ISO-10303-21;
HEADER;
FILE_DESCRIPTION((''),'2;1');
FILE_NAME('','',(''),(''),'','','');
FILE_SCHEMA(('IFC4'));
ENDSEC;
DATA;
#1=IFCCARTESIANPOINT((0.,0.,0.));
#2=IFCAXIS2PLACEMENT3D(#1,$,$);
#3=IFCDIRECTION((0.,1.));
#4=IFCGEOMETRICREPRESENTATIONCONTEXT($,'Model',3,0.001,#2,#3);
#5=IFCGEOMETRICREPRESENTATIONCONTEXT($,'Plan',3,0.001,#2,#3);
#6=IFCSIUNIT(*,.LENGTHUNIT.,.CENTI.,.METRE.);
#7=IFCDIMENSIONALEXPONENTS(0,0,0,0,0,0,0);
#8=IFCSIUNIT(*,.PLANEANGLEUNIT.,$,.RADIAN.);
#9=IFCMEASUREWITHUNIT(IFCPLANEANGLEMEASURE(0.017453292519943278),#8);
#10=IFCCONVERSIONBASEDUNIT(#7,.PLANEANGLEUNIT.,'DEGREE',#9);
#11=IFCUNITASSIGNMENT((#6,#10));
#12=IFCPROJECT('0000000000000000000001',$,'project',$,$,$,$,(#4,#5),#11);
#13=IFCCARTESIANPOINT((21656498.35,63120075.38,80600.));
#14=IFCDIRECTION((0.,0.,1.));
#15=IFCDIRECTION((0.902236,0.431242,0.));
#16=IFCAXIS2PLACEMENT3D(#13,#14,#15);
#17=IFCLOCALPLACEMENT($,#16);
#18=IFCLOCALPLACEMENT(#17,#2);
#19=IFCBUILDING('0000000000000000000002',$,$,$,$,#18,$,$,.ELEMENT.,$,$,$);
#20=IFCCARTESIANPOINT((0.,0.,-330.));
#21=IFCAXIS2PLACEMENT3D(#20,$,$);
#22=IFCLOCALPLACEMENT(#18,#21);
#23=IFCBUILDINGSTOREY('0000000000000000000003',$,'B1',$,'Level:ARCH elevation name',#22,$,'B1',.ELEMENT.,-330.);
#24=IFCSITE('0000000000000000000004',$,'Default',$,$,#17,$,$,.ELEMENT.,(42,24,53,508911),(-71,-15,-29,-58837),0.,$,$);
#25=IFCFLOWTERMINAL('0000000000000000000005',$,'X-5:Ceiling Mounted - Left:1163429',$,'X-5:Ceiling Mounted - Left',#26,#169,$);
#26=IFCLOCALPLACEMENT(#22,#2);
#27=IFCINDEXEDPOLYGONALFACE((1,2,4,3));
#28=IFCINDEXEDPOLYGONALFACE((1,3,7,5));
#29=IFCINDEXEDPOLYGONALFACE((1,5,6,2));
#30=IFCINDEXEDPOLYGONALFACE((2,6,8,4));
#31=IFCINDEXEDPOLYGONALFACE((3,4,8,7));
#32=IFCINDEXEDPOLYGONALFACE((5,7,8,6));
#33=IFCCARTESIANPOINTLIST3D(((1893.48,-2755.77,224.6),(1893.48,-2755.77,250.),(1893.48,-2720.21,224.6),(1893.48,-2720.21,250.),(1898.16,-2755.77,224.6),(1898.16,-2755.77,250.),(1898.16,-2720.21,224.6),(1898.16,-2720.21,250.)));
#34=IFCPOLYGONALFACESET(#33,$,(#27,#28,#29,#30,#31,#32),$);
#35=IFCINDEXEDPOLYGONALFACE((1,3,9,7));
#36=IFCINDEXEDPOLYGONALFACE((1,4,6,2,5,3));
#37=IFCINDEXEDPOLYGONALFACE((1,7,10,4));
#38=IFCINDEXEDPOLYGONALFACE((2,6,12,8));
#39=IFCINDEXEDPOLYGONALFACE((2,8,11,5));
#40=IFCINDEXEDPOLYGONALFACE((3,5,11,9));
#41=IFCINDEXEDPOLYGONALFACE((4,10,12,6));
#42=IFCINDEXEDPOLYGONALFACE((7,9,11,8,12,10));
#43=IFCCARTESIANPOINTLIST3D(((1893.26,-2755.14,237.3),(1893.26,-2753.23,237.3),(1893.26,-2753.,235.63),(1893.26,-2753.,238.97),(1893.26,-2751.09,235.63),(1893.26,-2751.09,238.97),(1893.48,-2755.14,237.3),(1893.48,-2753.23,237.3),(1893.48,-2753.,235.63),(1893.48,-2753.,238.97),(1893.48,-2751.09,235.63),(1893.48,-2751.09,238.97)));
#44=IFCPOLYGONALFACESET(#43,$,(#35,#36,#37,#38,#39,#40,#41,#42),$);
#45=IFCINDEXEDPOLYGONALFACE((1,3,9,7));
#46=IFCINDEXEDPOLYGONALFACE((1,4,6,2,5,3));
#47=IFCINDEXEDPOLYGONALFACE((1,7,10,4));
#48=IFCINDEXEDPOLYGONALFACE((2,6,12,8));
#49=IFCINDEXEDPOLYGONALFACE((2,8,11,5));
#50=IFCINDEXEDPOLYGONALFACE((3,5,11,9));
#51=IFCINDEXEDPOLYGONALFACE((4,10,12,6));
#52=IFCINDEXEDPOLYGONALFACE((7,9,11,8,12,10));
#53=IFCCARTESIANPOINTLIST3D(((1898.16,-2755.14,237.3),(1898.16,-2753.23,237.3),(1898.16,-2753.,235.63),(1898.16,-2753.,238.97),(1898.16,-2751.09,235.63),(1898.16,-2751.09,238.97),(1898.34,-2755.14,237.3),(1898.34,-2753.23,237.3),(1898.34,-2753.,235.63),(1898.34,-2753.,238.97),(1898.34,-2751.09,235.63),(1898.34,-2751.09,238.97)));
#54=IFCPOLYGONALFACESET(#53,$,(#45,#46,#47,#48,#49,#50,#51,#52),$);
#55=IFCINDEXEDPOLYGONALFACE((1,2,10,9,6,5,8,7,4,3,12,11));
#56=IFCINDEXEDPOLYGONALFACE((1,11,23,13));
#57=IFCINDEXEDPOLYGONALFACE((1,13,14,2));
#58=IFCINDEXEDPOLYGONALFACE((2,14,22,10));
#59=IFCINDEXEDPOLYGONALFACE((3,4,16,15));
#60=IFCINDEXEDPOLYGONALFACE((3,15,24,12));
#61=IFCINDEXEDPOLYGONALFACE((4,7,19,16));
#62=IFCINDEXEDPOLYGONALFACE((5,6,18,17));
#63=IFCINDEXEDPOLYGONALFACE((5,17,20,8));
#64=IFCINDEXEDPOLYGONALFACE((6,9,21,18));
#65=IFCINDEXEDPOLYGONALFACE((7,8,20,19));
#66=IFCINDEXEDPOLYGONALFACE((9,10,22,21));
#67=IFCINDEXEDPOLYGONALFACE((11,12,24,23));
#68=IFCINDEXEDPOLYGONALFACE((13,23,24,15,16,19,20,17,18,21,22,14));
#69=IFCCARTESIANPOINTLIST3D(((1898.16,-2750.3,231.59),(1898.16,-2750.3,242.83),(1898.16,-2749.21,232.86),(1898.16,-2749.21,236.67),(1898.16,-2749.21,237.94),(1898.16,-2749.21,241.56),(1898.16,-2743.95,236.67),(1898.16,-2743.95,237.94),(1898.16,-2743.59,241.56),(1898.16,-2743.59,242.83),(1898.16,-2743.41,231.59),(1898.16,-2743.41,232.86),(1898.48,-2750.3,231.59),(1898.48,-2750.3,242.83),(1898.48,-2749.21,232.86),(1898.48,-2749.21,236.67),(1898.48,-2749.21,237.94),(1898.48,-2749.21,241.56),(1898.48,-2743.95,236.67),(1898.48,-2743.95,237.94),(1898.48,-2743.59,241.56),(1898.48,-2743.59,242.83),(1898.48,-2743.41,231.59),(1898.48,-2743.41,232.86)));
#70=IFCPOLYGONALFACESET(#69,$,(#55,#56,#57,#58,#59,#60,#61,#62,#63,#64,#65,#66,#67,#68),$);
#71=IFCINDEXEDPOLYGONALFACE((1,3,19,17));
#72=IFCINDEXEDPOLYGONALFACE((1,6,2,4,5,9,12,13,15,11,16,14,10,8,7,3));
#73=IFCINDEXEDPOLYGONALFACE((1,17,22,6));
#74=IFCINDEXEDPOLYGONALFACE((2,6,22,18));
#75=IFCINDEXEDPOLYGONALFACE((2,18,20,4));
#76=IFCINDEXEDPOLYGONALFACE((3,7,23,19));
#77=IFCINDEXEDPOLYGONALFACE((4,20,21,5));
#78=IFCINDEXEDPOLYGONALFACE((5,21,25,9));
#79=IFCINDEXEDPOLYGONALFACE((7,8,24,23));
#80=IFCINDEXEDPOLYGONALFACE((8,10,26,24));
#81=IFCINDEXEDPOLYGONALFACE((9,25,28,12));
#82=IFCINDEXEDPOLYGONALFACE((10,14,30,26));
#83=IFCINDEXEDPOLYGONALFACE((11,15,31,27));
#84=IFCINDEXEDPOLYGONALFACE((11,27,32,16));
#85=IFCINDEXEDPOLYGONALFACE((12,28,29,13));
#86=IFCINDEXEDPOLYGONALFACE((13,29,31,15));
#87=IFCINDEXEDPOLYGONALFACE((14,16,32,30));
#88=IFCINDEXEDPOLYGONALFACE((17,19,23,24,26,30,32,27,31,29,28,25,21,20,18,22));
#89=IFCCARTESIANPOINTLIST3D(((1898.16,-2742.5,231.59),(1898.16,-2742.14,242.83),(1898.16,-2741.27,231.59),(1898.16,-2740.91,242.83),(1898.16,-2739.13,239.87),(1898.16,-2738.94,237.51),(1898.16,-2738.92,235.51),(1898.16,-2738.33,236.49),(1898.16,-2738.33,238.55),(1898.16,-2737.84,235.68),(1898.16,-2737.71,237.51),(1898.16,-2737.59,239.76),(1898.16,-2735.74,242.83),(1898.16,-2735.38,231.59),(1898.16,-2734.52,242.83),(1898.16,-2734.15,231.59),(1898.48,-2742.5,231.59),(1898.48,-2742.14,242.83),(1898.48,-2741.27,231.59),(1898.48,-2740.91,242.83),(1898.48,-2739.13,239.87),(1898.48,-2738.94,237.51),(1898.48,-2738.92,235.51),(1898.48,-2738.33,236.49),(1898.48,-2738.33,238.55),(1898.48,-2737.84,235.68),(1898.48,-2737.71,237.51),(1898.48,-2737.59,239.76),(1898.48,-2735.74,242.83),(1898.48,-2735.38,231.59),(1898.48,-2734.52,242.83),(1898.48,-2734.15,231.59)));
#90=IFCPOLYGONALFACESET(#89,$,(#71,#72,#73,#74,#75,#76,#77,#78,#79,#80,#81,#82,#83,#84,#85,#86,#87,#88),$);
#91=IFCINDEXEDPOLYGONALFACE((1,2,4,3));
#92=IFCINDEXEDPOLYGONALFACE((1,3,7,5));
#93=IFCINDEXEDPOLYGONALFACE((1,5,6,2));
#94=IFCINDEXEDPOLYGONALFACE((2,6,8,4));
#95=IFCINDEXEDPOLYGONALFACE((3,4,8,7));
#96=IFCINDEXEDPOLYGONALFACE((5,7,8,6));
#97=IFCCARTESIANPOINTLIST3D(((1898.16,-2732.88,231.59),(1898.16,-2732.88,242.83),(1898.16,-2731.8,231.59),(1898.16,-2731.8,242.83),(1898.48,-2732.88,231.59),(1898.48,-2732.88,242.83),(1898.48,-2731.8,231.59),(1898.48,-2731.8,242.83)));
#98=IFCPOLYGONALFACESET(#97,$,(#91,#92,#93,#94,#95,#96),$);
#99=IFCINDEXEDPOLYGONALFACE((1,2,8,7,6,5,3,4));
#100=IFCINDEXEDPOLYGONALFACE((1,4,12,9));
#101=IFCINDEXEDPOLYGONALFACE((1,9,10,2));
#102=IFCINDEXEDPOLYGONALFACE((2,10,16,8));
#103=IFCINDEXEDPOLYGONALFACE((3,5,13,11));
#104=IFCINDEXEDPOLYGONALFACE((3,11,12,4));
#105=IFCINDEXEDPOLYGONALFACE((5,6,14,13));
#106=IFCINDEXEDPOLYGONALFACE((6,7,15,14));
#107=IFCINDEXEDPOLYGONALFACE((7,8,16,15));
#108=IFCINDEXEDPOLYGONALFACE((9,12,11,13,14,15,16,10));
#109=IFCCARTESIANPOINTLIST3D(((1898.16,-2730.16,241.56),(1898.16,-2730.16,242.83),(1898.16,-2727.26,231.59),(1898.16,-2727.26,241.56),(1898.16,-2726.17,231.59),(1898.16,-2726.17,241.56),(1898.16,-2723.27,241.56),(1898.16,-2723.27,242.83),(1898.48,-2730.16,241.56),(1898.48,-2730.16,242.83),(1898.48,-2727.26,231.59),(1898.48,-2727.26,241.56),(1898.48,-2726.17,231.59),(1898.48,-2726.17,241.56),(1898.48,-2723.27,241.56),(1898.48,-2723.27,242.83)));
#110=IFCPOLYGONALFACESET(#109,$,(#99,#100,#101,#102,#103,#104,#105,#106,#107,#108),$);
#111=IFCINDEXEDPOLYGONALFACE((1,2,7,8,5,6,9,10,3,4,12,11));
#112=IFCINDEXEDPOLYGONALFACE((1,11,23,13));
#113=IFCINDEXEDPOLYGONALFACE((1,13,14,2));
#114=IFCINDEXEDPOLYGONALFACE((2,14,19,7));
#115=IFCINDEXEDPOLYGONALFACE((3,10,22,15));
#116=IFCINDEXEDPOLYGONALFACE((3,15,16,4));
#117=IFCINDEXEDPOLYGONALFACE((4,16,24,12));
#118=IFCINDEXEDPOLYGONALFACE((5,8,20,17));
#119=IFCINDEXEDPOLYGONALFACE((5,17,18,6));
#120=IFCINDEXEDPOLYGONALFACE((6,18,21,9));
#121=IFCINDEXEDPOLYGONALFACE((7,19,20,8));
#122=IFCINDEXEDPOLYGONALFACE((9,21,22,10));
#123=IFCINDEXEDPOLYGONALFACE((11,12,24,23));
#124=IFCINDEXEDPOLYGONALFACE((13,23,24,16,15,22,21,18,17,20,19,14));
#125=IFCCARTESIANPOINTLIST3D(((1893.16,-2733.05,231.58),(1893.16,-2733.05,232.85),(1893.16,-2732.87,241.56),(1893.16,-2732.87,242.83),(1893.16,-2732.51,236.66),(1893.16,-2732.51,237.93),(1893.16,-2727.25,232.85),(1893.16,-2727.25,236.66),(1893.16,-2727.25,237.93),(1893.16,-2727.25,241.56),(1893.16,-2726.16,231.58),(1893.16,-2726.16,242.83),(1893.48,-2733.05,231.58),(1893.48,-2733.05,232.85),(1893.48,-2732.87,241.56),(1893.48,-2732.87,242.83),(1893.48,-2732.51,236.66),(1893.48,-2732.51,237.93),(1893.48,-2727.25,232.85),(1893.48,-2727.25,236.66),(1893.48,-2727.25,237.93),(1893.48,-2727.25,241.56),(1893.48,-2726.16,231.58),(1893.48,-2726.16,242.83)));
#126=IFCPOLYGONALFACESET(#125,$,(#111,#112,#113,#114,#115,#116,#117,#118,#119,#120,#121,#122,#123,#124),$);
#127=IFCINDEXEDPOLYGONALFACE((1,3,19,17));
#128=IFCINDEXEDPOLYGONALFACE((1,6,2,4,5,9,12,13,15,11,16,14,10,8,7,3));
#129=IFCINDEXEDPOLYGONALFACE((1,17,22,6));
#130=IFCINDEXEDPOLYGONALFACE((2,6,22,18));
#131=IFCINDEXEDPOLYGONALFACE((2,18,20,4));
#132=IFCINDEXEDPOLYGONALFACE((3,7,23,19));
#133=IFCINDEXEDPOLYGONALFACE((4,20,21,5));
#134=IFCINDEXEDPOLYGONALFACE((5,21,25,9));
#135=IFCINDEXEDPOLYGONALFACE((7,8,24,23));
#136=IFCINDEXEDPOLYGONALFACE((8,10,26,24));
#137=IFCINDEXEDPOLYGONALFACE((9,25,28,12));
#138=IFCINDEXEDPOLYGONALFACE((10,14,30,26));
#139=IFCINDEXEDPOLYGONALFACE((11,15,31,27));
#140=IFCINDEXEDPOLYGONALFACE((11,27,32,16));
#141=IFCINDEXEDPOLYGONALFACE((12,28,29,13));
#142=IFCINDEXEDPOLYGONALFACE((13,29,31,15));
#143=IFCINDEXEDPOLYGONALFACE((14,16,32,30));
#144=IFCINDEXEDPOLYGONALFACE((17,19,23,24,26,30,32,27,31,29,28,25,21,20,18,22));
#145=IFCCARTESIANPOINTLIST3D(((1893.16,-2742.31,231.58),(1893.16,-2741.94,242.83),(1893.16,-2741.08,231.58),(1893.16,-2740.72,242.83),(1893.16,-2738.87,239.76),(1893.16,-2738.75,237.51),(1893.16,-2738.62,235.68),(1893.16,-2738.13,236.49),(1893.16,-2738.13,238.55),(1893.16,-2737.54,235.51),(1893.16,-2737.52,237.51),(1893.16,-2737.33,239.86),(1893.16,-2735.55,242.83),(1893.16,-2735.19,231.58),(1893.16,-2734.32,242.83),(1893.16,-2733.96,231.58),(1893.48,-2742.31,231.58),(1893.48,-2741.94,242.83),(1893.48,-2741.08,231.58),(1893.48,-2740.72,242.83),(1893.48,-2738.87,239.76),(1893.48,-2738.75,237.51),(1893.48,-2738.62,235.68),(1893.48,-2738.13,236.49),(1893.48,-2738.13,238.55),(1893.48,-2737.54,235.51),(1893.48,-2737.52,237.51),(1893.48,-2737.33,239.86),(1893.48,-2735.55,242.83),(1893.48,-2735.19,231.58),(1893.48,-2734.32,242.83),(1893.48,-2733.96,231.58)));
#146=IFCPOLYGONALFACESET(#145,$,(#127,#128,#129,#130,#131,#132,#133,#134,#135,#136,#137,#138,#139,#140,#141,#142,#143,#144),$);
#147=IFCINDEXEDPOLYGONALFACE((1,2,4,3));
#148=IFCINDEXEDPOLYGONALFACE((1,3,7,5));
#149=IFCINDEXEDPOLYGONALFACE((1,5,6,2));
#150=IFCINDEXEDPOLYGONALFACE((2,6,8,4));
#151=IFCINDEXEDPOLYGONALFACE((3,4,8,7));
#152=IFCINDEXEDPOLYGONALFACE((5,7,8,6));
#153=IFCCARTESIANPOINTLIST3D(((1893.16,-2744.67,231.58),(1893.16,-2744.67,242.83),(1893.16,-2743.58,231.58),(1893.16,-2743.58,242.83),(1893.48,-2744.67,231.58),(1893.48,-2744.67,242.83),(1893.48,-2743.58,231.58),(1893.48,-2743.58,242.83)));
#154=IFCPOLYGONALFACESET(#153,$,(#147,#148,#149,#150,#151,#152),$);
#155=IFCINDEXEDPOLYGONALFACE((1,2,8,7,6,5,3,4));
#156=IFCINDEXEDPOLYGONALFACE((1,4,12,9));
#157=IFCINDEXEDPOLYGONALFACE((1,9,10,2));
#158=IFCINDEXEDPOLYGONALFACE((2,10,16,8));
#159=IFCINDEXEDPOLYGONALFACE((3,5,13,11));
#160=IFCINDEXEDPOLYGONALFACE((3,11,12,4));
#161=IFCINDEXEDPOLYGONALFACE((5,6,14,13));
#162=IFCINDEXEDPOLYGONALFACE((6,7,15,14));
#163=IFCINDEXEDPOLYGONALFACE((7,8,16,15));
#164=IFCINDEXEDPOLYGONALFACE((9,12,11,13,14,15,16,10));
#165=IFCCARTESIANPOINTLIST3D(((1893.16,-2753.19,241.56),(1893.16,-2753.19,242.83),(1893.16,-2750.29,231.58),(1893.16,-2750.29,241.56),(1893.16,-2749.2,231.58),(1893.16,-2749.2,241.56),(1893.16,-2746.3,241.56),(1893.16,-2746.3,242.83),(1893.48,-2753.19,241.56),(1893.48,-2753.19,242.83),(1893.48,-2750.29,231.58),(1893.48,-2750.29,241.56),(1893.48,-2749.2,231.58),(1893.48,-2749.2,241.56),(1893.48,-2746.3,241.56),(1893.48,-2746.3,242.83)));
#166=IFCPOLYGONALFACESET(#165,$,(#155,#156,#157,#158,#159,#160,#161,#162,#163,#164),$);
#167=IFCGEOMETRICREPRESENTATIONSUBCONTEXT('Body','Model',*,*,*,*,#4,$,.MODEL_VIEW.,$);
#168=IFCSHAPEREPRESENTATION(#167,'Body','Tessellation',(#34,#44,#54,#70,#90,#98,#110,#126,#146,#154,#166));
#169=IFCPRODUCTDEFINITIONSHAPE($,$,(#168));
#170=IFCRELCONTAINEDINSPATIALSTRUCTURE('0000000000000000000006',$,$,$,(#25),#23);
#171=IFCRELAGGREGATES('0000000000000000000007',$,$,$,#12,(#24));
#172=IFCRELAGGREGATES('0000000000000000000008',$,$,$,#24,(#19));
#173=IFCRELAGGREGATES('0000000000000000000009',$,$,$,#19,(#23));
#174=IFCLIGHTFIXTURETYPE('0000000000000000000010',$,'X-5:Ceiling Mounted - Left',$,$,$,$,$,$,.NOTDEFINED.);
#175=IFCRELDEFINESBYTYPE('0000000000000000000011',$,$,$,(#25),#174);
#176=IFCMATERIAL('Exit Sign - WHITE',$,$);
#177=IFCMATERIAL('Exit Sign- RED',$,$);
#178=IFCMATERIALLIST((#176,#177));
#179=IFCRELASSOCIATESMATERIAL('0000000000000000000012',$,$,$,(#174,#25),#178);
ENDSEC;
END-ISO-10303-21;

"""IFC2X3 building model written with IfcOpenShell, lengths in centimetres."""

from ifc_helpers import new_model, entity, si_unit, converted_unit, direction, frame, frame_2d, origin, place, context, subcontext, project, spatial, polyline, rectangle, outline, extrude, source, transform, mapped, material, material_list, type_object, type_shapes, element, save


model = new_model("IFC2X3")

# Units and contexts
model_context = context("Model", 3, precision=0.001, world=origin(), true_north=direction((0.0, 1.0)))
plan_context = context("Plan", 3, precision=0.001, world=origin(), true_north=direction((0.0, 1.0)))
body_context = subcontext(model_context, "Body", "Model", "MODEL_VIEW")
ifc_project = project(units=[si_unit("LENGTHUNIT", "METRE", prefix="CENTI"), converted_unit("PLANEANGLEUNIT", "DEGREE", entity("IfcPlaneAngleMeasure", 0.017453292519943278), si_unit("PLANEANGLEUNIT", "RADIAN"), dimensions=[0, 0, 0, 0, 0, 0, 0])], contexts=[model_context, plan_context])

# Site, building, storey
site_placement = place(None, frame((21656498.35, 63120075.38, 80600.0), z_axis=(0.0, 0.0, 1.0), x_axis=(0.902236, 0.431242, 0.0)))
site = spatial("IfcSite", under=ifc_project, at=site_placement, Name="Default", CompositionType="ELEMENT", RefLatitude=(42, 24, 53, 508911), RefLongitude=(-71, -15, -29, -58837), RefElevation=0.0)
building_placement = place(site_placement, origin())
building = spatial("IfcBuilding", under=site, at=building_placement, CompositionType="ELEMENT")
storey_placement = place(building_placement, frame((0.0, 0.0, -330.0)))
storey = spatial("IfcBuildingStorey", under=building, at=storey_placement, Name="B1", ObjectType="Level:ARCH elevation name", LongName="B1", CompositionType="ELEMENT", Elevation=-330.0)

# Flow terminal
ifc_material_1 = material(Name="Exit Sign - WHITE")
ifc_material_2 = material(Name="Exit Sign- RED")
ifc_material_list_1 = material_list([ifc_material_1, ifc_material_2])
light_fixture_type_1 = type_object("IfcLightFixtureType", Name="X-5:Ceiling Mounted - Left", PredefinedType="NOTDEFINED", material=ifc_material_list_1)
shared_shape_1 = source(origin(), body_context, "Body", "SweptSolid", [
    extrude(rectangle(XDim=4.68, YDim=35.56, at=frame_2d((0.0, 0.0), x_axis=(1.0, 0.0))), frame((0.0, 1.02, -25.4), z_axis=(0.0, 0.0, 1.0), x_axis=(0.0, 1.0, 0.0)), (0.0, 0.0, 1.0), 25.4),
    extrude(outline(polyline([(-0.24, -1.67), (1.67, -1.67), (-0.47, 0.0), (1.67, 1.67), (-0.24, 1.67), (-2.38, 0.0), (-0.24, -1.67)])), frame((-14.77, 3.36, -12.7), z_axis=(0.0, 1.0, 0.0), x_axis=(1.0, 0.0, 0.0)), (0.0, 0.0, 1.0), 0.22),
    extrude(outline(polyline([(-0.24, -1.67), (1.67, -1.67), (-0.47, 0.0), (1.67, 1.67), (-0.24, 1.67), (-2.38, 0.0), (-0.24, -1.67)])), frame((-14.77, -1.49, -12.7), z_axis=(0.0, 1.0, 0.0), x_axis=(1.0, 0.0, 0.0)), (0.0, 0.0, 1.0), 0.18),
    extrude(outline(polyline([(-5.65, -3.69), (5.59, -3.69), (5.59, 3.02), (4.32, 3.02), (4.32, -2.6), (0.7, -2.6), (0.7, 2.66), (-0.57, 2.66), (-0.57, -2.6), (-4.38, -2.6), (-4.38, 3.21), (-5.65, 3.21), (-5.65, -3.69)])), frame((-8.62, -1.63, -12.76), z_axis=(0.0, 1.0, 0.0), x_axis=(0.0, 0.0, 1.0)), (0.0, 0.0, 1.0), 0.32),
    extrude(outline(polyline([(-7.14, 0.57), (-6.5, -0.49), (-1.93, -0.48), (-0.78, -0.48), (-1.23, -1.32), (-3.47, -5.53), (-2.84, -6.59), (0.41, -0.48), (6.62, -0.48), (5.99, 0.57), (2.4, 0.57), (0.98, 0.58), (1.7, 1.94), (3.32, 5.0), (2.69, 6.05), (-0.22, 0.57), (-7.14, 0.57)])), frame((-0.34, -1.63, -12.59), z_axis=(0.0, -1.0, 0.0), x_axis=(0.515099, 0.0, 0.857131)), (0.0, 0.0, -1.0), 0.32),
    extrude(rectangle(XDim=0.32, YDim=1.09, at=frame_2d((0.0, 0.0), x_axis=(1.0, 0.0))), frame((5.65, -1.48, -18.41), z_axis=(0.0, 0.0, 1.0), x_axis=(0.0, 1.0, 0.0)), (0.0, 0.0, 1.0), 11.25),
    extrude(outline(polyline([(-7.8, 0.54), (-7.8, -0.54), (2.18, -0.54), (2.18, -3.45), (3.45, -3.45), (3.45, 3.45), (2.18, 3.45), (2.18, 0.54), (-7.8, 0.54)])), frame((11.28, -1.63, -10.61), z_axis=(0.0, -1.0, 0.0), x_axis=(0.0, 0.0, 1.0)), (0.0, 0.0, -1.0), 0.32),
    extrude(outline(polyline([(-3.69, -5.65), (3.21, -5.65), (3.21, -4.38), (-2.6, -4.38), (-2.6, -0.57), (2.66, -0.57), (2.66, 0.7), (-2.6, 0.7), (-2.6, 4.32), (3.02, 4.32), (3.02, 5.59), (-3.69, 5.59), (-3.69, -5.65)])), frame((8.14, 3.36, -12.76), z_axis=(0.0, 1.0, 0.0), x_axis=(-1.0, 0.0, 0.0)), (0.0, 0.0, 1.0), 0.32),
    extrude(outline(polyline([(-4.16, -5.82), (-2.93, -5.82), (-0.58, -1.9), (0.01, -0.92), (0.5, -1.73), (2.96, -5.82), (4.18, -5.82), (0.62, 0.1), (3.82, 5.42), (2.59, 5.42), (0.75, 2.35), (0.01, 1.14), (-0.79, 2.46), (-2.57, 5.42), (-3.8, 5.42), (-0.6, 0.1), (-4.16, -5.82)])), frame((-0.13, 3.36, -12.59), z_axis=(0.0, 1.0, 0.0), x_axis=(-1.0, 0.0, 0.0)), (0.0, 0.0, 1.0), 0.32),
    extrude(rectangle(XDim=0.32, YDim=1.09, at=frame_2d((0.0, 0.0), x_axis=(1.0, 0.0))), frame((-6.13, 3.52, -18.42), z_axis=(0.0, 0.0, 1.0), x_axis=(0.0, -1.0, 0.0)), (0.0, 0.0, 1.0), 11.25),
    extrude(outline(polyline([(-0.54, -7.8), (0.54, -7.8), (0.54, 2.18), (3.45, 2.18), (3.45, 3.45), (-3.45, 3.45), (-3.45, 2.18), (-0.54, 2.18), (-0.54, -7.8)])), frame((-11.75, 3.36, -10.62), z_axis=(0.0, 1.0, 0.0), x_axis=(-1.0, 0.0, 0.0)), (0.0, 0.0, 1.0), 0.32),
])
type_shapes(light_fixture_type_1, [shared_shape_1])
for number, where, z_axis, x_axis, name in (
    (1, (1896.84, -2737.99, 250.0), (0.0, 0.0, 1.0), (0.0, 1.0, 0.0), "X-5:Ceiling Mounted - Left:1163429"),
):
    element("IfcFlowTerminal", number, at=place(storey_placement, frame(where, z_axis=z_axis, x_axis=x_axis)), inside=storey, type_object=light_fixture_type_1, material=ifc_material_list_1, Name=name, ObjectType="X-5:Ceiling Mounted - Left", context=body_context, shape_type="MappedRepresentation", body=[
        mapped(shared_shape_1, transform((0.0, 0.0, 0.0), scale=1.0)),
    ])

save(model, "model.ifc")
